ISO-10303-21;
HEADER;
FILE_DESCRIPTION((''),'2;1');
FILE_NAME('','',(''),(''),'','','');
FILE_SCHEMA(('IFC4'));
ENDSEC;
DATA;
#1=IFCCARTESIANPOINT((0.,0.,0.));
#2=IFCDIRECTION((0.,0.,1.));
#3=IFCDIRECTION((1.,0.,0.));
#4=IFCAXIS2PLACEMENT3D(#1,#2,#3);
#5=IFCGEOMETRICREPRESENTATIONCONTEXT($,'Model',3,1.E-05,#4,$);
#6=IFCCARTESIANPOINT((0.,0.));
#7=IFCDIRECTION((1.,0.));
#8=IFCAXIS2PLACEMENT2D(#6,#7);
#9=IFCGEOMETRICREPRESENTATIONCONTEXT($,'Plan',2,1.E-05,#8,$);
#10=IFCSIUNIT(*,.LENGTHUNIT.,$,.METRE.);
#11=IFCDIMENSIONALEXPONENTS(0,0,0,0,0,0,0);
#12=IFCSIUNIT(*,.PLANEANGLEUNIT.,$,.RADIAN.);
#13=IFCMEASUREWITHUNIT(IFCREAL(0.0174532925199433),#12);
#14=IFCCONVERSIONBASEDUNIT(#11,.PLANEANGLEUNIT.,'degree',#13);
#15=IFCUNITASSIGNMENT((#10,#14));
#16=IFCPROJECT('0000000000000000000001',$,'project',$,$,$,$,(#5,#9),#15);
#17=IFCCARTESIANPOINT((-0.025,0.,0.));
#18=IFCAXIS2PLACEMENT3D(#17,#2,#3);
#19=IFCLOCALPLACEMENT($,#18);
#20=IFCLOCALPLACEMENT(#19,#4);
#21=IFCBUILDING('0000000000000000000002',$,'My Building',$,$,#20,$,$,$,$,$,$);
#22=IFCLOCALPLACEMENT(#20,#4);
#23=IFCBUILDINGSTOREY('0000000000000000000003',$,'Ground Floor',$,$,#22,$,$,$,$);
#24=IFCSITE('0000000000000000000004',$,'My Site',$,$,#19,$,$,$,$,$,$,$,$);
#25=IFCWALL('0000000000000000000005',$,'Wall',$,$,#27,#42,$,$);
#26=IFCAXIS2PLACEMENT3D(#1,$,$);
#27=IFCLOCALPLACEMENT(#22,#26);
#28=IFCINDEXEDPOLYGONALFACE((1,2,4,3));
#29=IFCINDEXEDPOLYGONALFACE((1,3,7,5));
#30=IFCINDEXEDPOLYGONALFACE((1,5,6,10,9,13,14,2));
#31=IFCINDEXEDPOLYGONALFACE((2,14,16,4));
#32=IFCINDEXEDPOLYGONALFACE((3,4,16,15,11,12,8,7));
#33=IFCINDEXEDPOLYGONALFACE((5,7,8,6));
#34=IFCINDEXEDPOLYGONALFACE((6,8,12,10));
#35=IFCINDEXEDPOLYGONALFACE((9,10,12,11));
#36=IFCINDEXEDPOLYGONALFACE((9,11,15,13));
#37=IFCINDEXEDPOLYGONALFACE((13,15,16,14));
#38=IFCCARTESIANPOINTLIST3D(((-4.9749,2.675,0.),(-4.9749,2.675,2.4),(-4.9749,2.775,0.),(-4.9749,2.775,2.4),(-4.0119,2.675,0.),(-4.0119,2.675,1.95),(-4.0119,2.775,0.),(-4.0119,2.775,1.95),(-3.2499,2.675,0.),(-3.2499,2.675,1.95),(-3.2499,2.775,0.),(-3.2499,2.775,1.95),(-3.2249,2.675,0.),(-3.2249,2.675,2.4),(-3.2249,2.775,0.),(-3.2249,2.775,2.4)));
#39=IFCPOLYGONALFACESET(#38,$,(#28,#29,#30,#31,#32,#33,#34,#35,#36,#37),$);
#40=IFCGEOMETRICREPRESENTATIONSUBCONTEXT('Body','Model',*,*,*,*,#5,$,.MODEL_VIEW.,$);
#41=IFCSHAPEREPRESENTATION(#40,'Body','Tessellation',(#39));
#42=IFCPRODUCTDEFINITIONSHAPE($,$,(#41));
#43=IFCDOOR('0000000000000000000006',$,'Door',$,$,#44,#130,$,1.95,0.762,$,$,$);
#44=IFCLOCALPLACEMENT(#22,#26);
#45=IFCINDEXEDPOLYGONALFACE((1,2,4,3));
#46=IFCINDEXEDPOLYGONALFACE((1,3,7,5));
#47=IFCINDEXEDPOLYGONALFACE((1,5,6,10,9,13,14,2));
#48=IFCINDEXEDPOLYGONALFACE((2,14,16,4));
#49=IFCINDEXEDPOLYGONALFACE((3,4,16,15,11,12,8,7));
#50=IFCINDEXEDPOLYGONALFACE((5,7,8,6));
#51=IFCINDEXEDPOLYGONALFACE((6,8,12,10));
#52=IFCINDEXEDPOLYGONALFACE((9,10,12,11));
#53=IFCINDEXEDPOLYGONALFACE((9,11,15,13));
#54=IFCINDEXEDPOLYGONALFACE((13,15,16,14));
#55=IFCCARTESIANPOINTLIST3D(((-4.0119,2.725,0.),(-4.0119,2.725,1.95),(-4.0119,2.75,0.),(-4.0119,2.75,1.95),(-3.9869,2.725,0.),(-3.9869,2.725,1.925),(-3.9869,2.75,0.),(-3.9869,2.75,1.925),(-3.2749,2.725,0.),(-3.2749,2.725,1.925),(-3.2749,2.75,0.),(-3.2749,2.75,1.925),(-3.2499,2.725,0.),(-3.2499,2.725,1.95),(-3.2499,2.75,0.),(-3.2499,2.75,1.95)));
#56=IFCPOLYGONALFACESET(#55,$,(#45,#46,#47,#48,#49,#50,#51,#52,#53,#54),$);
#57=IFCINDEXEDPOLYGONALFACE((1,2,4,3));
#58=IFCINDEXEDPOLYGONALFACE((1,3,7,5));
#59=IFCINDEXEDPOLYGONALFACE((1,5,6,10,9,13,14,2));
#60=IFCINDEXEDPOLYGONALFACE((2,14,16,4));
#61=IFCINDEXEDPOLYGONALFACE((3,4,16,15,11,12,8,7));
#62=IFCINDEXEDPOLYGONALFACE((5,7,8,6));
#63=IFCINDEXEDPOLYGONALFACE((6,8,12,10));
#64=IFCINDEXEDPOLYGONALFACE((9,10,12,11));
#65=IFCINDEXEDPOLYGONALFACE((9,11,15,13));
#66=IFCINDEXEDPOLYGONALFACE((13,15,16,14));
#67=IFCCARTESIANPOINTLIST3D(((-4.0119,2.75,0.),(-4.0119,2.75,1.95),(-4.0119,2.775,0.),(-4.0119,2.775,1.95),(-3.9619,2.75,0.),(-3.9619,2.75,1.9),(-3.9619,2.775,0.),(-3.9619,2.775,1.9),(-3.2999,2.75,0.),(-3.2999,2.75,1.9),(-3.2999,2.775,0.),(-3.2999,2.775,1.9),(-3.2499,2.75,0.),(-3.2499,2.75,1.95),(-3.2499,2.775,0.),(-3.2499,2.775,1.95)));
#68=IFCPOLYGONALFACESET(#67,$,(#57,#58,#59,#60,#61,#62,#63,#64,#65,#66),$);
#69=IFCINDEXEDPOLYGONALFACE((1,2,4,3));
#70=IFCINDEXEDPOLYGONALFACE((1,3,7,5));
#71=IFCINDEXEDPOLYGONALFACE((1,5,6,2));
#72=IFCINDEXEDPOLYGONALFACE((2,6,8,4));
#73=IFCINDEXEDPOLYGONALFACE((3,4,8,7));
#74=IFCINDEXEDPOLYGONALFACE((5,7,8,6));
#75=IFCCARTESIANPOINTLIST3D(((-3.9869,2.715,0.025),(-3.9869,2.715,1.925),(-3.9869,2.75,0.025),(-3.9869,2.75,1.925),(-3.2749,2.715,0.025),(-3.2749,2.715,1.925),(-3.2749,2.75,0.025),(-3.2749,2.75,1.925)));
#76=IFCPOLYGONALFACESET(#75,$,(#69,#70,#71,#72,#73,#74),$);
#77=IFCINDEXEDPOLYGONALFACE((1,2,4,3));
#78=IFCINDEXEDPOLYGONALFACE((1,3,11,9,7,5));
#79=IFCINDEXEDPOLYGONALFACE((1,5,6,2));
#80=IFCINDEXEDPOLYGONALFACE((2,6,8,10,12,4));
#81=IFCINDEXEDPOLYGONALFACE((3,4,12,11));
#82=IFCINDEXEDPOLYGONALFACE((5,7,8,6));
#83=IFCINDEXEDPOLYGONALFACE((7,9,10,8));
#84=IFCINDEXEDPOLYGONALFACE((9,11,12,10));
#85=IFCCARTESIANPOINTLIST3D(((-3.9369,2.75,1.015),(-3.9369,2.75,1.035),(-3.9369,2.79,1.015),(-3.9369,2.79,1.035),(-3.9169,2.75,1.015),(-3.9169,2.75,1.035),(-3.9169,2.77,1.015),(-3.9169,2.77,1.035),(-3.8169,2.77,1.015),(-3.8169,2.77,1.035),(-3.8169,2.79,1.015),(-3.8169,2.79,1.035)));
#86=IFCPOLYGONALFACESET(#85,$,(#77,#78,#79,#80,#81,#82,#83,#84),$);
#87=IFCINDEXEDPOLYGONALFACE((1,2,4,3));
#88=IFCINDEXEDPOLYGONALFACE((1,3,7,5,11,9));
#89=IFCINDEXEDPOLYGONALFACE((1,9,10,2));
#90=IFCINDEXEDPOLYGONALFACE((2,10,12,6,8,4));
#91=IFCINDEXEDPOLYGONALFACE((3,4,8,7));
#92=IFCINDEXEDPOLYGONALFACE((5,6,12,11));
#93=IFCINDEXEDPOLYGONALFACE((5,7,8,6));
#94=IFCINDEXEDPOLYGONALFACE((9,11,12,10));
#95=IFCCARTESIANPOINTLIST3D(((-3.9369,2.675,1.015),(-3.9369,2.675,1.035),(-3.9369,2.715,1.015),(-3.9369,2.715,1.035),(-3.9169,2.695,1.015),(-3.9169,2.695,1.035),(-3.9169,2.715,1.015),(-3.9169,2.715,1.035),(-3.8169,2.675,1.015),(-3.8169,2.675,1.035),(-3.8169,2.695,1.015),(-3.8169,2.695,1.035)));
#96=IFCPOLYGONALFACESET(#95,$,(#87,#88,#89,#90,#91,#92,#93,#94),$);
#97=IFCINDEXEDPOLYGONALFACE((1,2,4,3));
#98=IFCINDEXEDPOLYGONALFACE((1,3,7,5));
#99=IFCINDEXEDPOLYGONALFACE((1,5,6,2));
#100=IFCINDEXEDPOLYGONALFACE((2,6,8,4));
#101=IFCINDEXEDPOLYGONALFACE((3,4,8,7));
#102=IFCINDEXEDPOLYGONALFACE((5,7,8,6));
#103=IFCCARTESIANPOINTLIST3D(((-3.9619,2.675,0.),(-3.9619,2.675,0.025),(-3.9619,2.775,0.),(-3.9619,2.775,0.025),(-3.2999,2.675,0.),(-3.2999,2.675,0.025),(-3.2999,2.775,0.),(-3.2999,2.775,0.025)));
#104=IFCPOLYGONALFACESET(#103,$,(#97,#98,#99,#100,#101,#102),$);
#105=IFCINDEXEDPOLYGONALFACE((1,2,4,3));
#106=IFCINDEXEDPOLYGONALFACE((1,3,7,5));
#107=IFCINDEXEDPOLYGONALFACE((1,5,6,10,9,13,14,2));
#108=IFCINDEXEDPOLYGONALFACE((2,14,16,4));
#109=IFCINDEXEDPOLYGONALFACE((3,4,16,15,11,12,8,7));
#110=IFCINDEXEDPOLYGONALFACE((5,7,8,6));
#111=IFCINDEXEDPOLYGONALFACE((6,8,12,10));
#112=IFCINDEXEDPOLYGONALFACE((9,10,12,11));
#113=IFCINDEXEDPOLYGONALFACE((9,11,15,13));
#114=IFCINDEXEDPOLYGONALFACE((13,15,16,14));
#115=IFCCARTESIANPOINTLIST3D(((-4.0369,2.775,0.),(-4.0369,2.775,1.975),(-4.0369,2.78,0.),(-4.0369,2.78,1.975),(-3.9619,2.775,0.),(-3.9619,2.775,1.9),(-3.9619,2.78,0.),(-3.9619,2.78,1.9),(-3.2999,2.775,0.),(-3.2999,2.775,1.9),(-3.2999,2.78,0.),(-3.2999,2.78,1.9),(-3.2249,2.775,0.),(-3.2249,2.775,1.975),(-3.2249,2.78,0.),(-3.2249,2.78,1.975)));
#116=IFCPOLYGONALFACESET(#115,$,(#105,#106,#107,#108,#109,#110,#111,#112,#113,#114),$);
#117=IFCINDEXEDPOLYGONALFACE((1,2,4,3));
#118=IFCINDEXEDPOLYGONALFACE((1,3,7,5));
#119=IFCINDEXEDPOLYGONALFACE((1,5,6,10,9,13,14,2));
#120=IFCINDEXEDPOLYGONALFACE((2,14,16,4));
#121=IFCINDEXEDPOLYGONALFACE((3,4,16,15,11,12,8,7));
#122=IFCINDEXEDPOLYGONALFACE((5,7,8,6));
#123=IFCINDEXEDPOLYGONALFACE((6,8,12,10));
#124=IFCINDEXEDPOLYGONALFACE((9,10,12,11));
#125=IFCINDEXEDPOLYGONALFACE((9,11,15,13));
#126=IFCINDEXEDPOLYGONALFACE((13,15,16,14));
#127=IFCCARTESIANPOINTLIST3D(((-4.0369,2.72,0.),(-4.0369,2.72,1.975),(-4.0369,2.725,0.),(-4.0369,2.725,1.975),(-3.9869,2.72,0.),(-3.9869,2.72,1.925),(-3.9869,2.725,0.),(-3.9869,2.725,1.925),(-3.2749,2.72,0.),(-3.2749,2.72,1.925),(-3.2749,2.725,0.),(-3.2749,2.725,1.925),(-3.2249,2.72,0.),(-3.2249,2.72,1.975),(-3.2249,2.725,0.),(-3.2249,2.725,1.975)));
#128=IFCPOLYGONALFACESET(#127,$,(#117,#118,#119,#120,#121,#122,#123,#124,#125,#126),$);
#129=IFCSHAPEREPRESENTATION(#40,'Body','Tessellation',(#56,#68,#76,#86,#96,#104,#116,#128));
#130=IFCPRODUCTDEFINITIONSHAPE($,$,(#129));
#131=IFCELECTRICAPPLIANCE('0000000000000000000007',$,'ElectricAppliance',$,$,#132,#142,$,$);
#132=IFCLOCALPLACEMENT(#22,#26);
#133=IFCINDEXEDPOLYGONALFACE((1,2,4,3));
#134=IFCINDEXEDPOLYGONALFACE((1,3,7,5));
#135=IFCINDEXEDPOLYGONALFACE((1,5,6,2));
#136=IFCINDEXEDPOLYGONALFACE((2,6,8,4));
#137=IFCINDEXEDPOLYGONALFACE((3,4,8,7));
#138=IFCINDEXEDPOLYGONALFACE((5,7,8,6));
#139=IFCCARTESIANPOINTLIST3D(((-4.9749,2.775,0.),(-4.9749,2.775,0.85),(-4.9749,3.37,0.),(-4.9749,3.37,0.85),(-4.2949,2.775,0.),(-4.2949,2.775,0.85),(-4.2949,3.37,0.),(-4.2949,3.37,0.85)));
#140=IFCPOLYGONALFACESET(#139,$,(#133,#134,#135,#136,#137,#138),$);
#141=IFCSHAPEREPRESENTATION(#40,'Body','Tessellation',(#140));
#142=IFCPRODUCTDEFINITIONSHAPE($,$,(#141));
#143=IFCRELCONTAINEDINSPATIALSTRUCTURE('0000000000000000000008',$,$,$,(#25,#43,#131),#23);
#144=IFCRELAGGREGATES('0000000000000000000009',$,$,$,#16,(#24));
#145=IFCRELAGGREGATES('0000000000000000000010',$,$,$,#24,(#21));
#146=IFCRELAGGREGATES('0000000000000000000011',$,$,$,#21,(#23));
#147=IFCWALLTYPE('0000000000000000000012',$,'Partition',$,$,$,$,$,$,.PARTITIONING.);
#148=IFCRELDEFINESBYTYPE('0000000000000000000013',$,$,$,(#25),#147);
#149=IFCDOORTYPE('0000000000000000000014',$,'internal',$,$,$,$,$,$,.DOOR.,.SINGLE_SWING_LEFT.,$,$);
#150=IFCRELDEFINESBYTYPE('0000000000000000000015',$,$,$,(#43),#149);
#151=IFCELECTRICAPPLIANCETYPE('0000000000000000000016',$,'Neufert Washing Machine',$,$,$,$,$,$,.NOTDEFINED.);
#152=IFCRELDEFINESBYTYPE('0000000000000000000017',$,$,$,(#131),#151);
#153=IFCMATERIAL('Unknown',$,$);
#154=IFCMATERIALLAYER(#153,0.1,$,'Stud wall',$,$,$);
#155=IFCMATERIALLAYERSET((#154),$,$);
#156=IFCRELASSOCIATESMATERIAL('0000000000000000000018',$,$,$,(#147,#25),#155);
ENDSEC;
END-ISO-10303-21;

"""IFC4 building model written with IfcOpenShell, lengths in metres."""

from ifc_helpers import new_model, entity, si_unit, converted_unit, frame, origin_with_axes, origin_2d_with_axis, place, context, subcontext, project, spatial, line, indexed_curve, outline, extrude, shape, source, transform, mapped, material, layer, layer_set, layer_usage, type_object, type_shapes, element, fill, save


model = new_model("IFC4")

# Units and contexts
model_context = context("Model", 3, precision=1e-05, world=origin_with_axes())
plan_context = context("Plan", 2, precision=1e-05, world=origin_2d_with_axis())
body_context_1 = subcontext(model_context, "Body", "Model", "MODEL_VIEW")
body_context_2 = subcontext(plan_context, "Body", "Plan", "PLAN_VIEW")
ifc_project = project(units=[si_unit("LENGTHUNIT", "METRE"), converted_unit("PLANEANGLEUNIT", "degree", entity("IfcReal", 0.0174532925199433), si_unit("PLANEANGLEUNIT", "RADIAN"), dimensions=[0, 0, 0, 0, 0, 0, 0])], contexts=[model_context, plan_context])

# Site, building, storey
site_placement = place(None, frame((-0.025, 0.0, 0.0), z_axis=(0.0, 0.0, 1.0), x_axis=(1.0, 0.0, 0.0)))
site = spatial("IfcSite", under=ifc_project, at=site_placement, Name="My Site")
building_placement = place(site_placement, origin_with_axes())
building = spatial("IfcBuilding", under=site, at=building_placement, Name="My Building")
storey_placement = place(building_placement, frame((0.0, 0.0, 0.0), z_axis=(0.0, 0.0, 1.0), x_axis=(1.0, 0.0, 0.0)))
storey = spatial("IfcBuildingStorey", under=building, at=storey_placement, Name="Ground Floor")

# Shared definitions
ifc_material = material(Name="Unknown")
shared_shape_1 = source(origin_with_axes(), body_context_1, "Body", "SweptSolid", [
    extrude(outline(indexed_curve([(0.0, 0.0), (0.762, 0.0), (0.762, 1.95), (0.0, 1.95)], segments=[line(1, 2, 3, 4, 1)])), frame((0.0, -0.1, 0.0), z_axis=(0.0, -1.0, 0.0), x_axis=(1.0, 0.0, 0.0)), (0.0, 0.0, -1.0), 0.3),
])
door_type = type_object("IfcDoorType", Name="internal", OperationType="SINGLE_SWING_LEFT", PredefinedType="DOOR")
shared_shape_2 = source(origin_with_axes(), body_context_1, "Body", "SweptSolid", [
    extrude(outline(indexed_curve([(0.0, 0.0), (0.0, 1.95), (0.762, 1.95), (0.762, 0.0), (0.737, 0.0), (0.737, 1.925), (0.025, 1.925), (0.025, 0.0)], segments=[line(1, 2, 3, 4, 5, 6, 7, 8, 1)])), frame((0.0, 0.025, 0.0), z_axis=(0.0, -1.0, 0.0), x_axis=(1.0, 0.0, 0.0)), (0.0, 0.0, -1.0), 0.025),
    extrude(outline(indexed_curve([(0.0, 0.0), (0.0, 1.95), (0.762, 1.95), (0.762, 0.0), (0.712, 0.0), (0.712, 1.9), (0.05, 1.9), (0.05, 0.0)], segments=[line(1, 2, 3, 4, 5, 6, 7, 8, 1)])), frame((0.0, 0.0, 0.0), z_axis=(0.0, -1.0, 0.0), x_axis=(1.0, 0.0, 0.0)), (0.0, 0.0, -1.0), 0.025),
    extrude(outline(indexed_curve([(0.0, 0.0), (0.712, 0.0), (0.712, 0.035), (0.0, 0.035)], segments=[line(1, 2, 3, 4, 1)])), frame((0.025, 0.025, 0.025), z_axis=(0.0, 0.0, 1.0), x_axis=(1.0, 0.0, 0.0)), (0.0, 0.0, 1.0), 1.9),
    extrude(outline(indexed_curve([(0.0, 0.0), (0.0, -0.04), (-0.12, -0.04), (-0.12, -0.02), (-0.02, -0.02), (-0.02, 0.0)], segments=[line(1, 2, 3, 4, 5, 6, 1)])), frame((0.687, 0.025, 1.015), z_axis=(0.0, 0.0, 1.0), x_axis=(1.0, 0.0, 0.0)), (0.0, 0.0, 1.0), 0.02),
    extrude(outline(indexed_curve([(0.0, 0.0), (0.0, 0.04), (-0.12, 0.04), (-0.12, 0.02), (-0.02, 0.02), (-0.02, 0.0)], segments=[line(1, 2, 3, 4, 5, 6, 1)])), frame((0.687, 0.06, 1.015), z_axis=(0.0, 0.0, 1.0), x_axis=(1.0, 0.0, 0.0)), (0.0, 0.0, 1.0), 0.02),
    extrude(outline(indexed_curve([(0.0, 0.0), (0.662, 0.0), (0.662, 0.1), (0.0, 0.1)], segments=[line(1, 2, 3, 4, 1)])), frame((0.05, 0.0, 0.0), z_axis=(0.0, 0.0, 1.0), x_axis=(1.0, 0.0, 0.0)), (0.0, 0.0, 1.0), 0.025),
    extrude(outline(indexed_curve([(0.0, 0.0), (0.0, 1.975), (0.812, 1.975), (0.812, 0.0), (0.737, 0.0), (0.737, 1.9), (0.075, 1.9), (0.075, 0.0)], segments=[line(1, 2, 3, 4, 5, 6, 7, 8, 1)])), frame((-0.025, -0.005, 0.0), z_axis=(0.0, -1.0, 0.0), x_axis=(1.0, 0.0, 0.0)), (0.0, 0.0, -1.0), 0.005),
    extrude(outline(indexed_curve([(0.0, 0.0), (0.0, 1.975), (0.812, 1.975), (0.812, 0.0), (0.762, 0.0), (0.762, 1.925), (0.05, 1.925), (0.05, 0.0)], segments=[line(1, 2, 3, 4, 5, 6, 7, 8, 1)])), frame((-0.025, 0.05, 0.0), z_axis=(0.0, -1.0, 0.0), x_axis=(1.0, 0.0, 0.0)), (0.0, 0.0, -1.0), 0.005),
])
shared_shape_3 = source(origin_with_axes(), body_context_2, "Body", "Curve2D", [
    entity("IfcIndexedPolyCurve", entity("IfcCartesianPointList2D", [[0.0, 0.0], [0.0, 0.05], [0.025, 0.05], [0.025, 0.025], [0.05, 0.025], [0.05, 0.0]]), [entity("IfcLineIndex", [1, 2, 3, 4, 5, 6, 1])]),
    entity("IfcIndexedPolyCurve", entity("IfcCartesianPointList2D", [[0.762, 0.0], [0.762, 0.05], [0.737, 0.05], [0.737, 0.025], [0.712, 0.025], [0.712, 0.0]]), [entity("IfcLineIndex", [1, 2, 3, 4, 5, 6, 1])]),
    entity("IfcTrimmedCurve", entity("IfcEllipse", entity("IfcAxis2Placement2D", entity("IfcCartesianPoint", [0.06, 0.05]), entity("IfcDirection", [1.0, 0.0])), 0.677, 0.712), [entity("IfcCartesianPoint", [0.737, 0.05])], [entity("IfcCartesianPoint", [0.06, 0.762])], True, "CARTESIAN"),
    entity("IfcIndexedPolyCurve", entity("IfcCartesianPointList2D", [[0.025, 0.05], [0.06, 0.05], [0.06, 0.762], [0.025, 0.762]]), [entity("IfcLineIndex", [1, 2, 3, 4, 1])]),
])
type_shapes(door_type, [shared_shape_2, shared_shape_3])

# Wall, opening, door
ifc_layer_1 = layer(ifc_material, 0.1, Name="Stud wall")
ifc_layer_set_1 = layer_set([ifc_layer_1])
wall_type_1 = type_object("IfcWallType", Name="Partition", PredefinedType="PARTITIONING", material=ifc_layer_set_1)
ifc_layer_usage_1 = layer_usage(ifc_layer_set_1, "AXIS2", "POSITIVE", 0.0)
wall_1_placement = place(storey_placement, frame((-3.2249, 2.775, 0.0), z_axis=(0.0, 0.0, 1.0), x_axis=(-1.0, 0.0, 0.0)))
wall_1 = element("IfcWall", 1, at=wall_1_placement, inside=storey, type_object=wall_type_1, material=ifc_layer_usage_1, Name="Wall", context=body_context_1, shape_type="SweptSolid", body=[
    extrude(outline(indexed_curve([(0.0, 0.0), (0.0, 0.1), (1.75, 0.1), (1.75, 0.0), (0.0, 0.0)], self_intersect=False)), origin_with_axes(), (0.0, 0.0, 1.0), 2.4),
])
opening_1_placement = place(wall_1_placement, frame((0.025, 0.0, 0.0), z_axis=(0.0, 0.0, 1.0), x_axis=(1.0, 0.0, 0.0)))
opening_1 = element("IfcOpeningElement", 2, at=opening_1_placement, cuts=wall_1, PredefinedType="OPENING", context=body_context_1, shape_type="MappedRepresentation", body=[
    mapped(shared_shape_1, transform((0.0, 0.0, 0.0), x_axis=(1.0, 0.0, 0.0), y_axis=(0.0, 1.0, 0.0), z_axis=(0.0, 0.0, 1.0), scale=1.0)),
])
door_1_placement = place(opening_1_placement, frame((0.0, 0.0, 0.0), z_axis=(0.0, 0.0, 1.0), x_axis=(1.0, 0.0, 0.0)))
door_1 = element("IfcDoor", 3, at=door_1_placement, inside=storey, type_object=door_type, Name="Door", OverallHeight=1.95, OverallWidth=0.762, shapes=[
    shape(body_context_1, "Body", "MappedRepresentation", [mapped(shared_shape_2, transform((0.0, 0.0, 0.0), x_axis=(1.0, 0.0, 0.0), y_axis=(0.0, 1.0, 0.0), z_axis=(0.0, 0.0, 1.0), scale=1.0))]),
    shape(body_context_2, "Body", "MappedRepresentation", [mapped(shared_shape_3, transform((0.0, 0.0, 0.0), x_axis=(1.0, 0.0, 0.0), y_axis=(0.0, 1.0, 0.0), z_axis=(0.0, 0.0, 1.0), scale=1.0))]),
])
fill(opening_1, door_1)

# Electric appliance
electric_appliance_type_1 = type_object("IfcElectricApplianceType", Name="Neufert Washing Machine", PredefinedType="NOTDEFINED")
shared_shape_4 = source(origin_with_axes(), body_context_1, "Body", "SweptSolid", [
    extrude(outline(indexed_curve([(0.0, 0.0), (0.595, 0.0), (0.595, 0.68), (0.0, 0.68)], segments=[line(1, 2, 3, 4, 1)])), origin_with_axes(), (0.0, 0.0, 1.0), 0.85),
])
shared_shape_5 = source(origin_with_axes(), body_context_2, "Body", "Curve2D", [
    entity("IfcIndexedPolyCurve", entity("IfcCartesianPointList2D", [[0.0, 0.0], [0.595, 0.0], [0.595, 0.68], [0.0, 0.68]]), [entity("IfcLineIndex", [1, 2, 3, 4, 1])]),
    entity("IfcCircle", entity("IfcAxis2Placement2D", entity("IfcCartesianPoint", [0.2975, 0.34])), 0.1785),
    entity("IfcCircle", entity("IfcAxis2Placement2D", entity("IfcCartesianPoint", [0.2975, 0.34])), 0.0595),
])
type_shapes(electric_appliance_type_1, [shared_shape_4, shared_shape_5])
electric_appliance_1_placement = place(storey_placement, frame((-4.2949, 2.775, 0.0), z_axis=(0.0, 0.0, 1.0), x_axis=(0.0, 1.0, 0.0)))
element("IfcElectricAppliance", 4, at=electric_appliance_1_placement, inside=storey, type_object=electric_appliance_type_1, Name="ElectricAppliance", shapes=[
    shape(body_context_1, "Body", "MappedRepresentation", [mapped(shared_shape_4, transform((0.0, 0.0, 0.0), x_axis=(1.0, 0.0, 0.0), y_axis=(0.0, 1.0, 0.0), z_axis=(0.0, 0.0, 1.0), scale=1.0))]),
    shape(body_context_2, "Body", "MappedRepresentation", [mapped(shared_shape_5, transform((0.0, 0.0, 0.0), x_axis=(1.0, 0.0, 0.0), y_axis=(0.0, 1.0, 0.0), z_axis=(0.0, 0.0, 1.0), scale=1.0))]),
])

save(model, "model.ifc")
